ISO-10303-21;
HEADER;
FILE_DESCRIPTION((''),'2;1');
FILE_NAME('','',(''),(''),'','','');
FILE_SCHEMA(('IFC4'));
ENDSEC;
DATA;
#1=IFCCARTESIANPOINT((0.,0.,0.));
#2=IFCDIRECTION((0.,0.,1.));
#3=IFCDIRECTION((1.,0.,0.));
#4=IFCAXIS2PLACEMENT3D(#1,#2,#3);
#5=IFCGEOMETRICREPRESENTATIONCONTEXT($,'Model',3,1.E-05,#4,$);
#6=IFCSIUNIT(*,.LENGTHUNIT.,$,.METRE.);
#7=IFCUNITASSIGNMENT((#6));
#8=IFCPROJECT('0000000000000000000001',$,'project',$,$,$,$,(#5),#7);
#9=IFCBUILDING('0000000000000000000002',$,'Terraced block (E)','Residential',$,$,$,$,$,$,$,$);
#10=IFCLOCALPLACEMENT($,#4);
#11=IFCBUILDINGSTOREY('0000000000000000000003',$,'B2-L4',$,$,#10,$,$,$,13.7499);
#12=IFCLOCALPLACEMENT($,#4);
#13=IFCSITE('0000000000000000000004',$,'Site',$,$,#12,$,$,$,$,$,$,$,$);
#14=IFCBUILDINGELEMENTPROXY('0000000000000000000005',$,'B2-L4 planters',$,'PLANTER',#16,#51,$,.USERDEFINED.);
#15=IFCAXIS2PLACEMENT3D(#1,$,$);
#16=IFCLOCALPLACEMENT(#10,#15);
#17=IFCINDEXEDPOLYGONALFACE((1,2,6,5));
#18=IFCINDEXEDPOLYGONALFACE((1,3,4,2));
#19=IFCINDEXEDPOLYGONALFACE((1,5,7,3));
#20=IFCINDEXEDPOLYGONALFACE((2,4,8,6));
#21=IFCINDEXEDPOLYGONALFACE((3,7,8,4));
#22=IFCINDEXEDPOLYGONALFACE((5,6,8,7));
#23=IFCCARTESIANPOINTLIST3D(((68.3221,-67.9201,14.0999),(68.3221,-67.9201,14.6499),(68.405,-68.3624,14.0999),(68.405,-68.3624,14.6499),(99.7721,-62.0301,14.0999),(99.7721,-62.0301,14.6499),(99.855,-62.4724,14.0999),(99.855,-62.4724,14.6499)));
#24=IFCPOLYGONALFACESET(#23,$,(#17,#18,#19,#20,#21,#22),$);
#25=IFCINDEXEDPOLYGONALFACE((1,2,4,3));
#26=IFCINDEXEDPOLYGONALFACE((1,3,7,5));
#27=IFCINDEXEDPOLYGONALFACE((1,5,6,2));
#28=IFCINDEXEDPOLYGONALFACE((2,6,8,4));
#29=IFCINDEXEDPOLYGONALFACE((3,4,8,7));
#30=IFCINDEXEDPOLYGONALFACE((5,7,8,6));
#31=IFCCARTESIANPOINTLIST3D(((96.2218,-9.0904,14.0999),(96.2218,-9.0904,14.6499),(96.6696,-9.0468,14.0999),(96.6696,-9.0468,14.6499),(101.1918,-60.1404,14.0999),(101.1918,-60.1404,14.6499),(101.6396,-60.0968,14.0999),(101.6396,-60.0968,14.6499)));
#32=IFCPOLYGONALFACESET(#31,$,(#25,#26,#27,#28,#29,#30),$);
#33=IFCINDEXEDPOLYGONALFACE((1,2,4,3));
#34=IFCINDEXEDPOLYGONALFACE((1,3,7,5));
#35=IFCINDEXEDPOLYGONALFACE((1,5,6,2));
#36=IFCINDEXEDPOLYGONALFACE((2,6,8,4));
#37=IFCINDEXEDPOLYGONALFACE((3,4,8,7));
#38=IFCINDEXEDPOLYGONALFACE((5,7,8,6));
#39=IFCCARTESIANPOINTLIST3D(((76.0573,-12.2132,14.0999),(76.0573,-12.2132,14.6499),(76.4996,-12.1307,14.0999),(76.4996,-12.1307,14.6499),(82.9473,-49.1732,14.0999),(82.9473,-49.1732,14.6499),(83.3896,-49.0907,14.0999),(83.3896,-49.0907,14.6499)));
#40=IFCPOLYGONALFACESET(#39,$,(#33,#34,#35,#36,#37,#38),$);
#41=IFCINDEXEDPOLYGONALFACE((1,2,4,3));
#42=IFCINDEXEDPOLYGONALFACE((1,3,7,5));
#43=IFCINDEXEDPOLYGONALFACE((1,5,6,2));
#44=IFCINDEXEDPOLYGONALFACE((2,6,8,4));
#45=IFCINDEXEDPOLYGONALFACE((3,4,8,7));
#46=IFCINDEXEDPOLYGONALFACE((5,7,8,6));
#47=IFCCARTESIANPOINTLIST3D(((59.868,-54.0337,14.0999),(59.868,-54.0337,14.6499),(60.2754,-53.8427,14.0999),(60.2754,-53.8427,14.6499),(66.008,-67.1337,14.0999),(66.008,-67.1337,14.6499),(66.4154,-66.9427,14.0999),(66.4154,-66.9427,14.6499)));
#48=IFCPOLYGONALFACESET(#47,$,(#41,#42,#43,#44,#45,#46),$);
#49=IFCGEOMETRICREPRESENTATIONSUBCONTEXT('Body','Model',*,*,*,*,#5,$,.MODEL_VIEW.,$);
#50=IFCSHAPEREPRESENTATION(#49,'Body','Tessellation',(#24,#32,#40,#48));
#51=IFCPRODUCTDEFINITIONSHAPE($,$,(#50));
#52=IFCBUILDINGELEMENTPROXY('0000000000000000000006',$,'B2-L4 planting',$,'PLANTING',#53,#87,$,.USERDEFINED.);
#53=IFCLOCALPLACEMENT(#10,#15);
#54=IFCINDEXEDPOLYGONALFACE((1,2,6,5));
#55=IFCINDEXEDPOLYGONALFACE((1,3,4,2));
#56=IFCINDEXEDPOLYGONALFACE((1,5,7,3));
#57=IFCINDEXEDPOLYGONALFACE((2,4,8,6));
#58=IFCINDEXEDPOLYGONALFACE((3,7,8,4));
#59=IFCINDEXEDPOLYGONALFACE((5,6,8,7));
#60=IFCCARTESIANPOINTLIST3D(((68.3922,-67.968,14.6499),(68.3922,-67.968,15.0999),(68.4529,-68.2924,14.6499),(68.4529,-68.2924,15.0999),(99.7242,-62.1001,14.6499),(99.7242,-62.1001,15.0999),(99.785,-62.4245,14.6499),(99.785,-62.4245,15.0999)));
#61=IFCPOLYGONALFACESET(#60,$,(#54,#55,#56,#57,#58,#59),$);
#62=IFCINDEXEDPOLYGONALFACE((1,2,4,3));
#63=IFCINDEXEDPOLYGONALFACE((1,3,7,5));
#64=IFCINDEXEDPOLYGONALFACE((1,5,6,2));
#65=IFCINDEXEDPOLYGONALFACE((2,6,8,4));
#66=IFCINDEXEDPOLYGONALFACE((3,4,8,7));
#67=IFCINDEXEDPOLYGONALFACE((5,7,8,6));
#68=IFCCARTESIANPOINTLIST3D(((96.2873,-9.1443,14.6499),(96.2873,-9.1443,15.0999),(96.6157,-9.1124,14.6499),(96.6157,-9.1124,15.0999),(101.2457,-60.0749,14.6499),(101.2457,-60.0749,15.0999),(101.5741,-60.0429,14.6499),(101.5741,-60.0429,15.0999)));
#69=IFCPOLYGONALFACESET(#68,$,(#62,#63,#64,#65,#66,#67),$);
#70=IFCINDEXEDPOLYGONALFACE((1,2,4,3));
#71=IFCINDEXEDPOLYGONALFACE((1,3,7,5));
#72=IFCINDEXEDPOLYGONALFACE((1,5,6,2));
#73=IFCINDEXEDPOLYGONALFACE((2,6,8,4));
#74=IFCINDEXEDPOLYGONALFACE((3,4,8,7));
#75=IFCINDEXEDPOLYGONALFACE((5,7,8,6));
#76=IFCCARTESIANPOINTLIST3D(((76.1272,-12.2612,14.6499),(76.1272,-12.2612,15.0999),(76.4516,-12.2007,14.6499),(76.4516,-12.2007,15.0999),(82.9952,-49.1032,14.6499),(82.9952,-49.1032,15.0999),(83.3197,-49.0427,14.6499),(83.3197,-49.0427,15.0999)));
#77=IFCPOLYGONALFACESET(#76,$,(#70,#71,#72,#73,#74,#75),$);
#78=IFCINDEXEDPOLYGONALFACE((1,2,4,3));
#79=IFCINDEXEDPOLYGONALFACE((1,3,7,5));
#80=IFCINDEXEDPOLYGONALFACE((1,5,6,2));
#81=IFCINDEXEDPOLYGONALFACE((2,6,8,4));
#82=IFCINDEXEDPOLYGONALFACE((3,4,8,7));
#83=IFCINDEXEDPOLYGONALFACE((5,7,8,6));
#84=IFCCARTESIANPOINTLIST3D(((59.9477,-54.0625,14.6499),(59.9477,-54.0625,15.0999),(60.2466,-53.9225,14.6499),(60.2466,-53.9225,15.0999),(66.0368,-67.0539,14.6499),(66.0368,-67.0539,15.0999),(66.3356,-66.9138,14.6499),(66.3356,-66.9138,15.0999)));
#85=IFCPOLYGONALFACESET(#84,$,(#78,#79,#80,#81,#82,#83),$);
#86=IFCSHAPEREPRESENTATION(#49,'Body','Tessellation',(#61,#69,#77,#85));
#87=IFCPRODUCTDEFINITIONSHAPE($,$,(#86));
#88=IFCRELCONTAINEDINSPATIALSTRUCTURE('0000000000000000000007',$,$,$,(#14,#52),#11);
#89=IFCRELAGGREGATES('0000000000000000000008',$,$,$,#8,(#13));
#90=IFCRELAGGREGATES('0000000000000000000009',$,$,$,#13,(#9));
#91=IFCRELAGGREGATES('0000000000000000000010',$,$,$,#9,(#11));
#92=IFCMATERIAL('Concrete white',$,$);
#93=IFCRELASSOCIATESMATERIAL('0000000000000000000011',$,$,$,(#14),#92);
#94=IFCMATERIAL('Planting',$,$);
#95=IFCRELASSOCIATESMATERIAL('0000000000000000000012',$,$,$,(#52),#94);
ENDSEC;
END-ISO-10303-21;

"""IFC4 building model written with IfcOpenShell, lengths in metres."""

from ifc_helpers import new_model, si_unit, frame, origin_with_axes, place, context, subcontext, project, spatial, polyline, outline, extrude, material, element, save


model = new_model("IFC4")

# Units and contexts
model_context = context("Model", 3, precision=1e-05, world=origin_with_axes())
body_context = subcontext(model_context, "Body", "Model", "MODEL_VIEW")
ifc_project = project(units=[si_unit("LENGTHUNIT", "METRE")], contexts=[model_context])

# Site, building, storey
site_placement = place(None, origin_with_axes())
site = spatial("IfcSite", under=ifc_project, at=site_placement, Name="Site")
building = spatial("IfcBuilding", under=site, Name="Terraced block (E)", Description="Residential")
storey_placement = place(None, origin_with_axes())
storey = spatial("IfcBuildingStorey", under=building, at=storey_placement, Name="B2-L4", Elevation=13.7499)

# Shared definitions
ifc_material_1 = material(Name="Concrete white")

# Building element proxies
proxy_1_placement = place(storey_placement, origin_with_axes())
element("IfcBuildingElementProxy", 1, at=proxy_1_placement, inside=storey, material=ifc_material_1, Name="B2-L4 planters", ObjectType="PLANTER", PredefinedType="USERDEFINED", context=body_context, shape_type="SweptSolid", body=[
    extrude(outline(polyline([(68.405, -68.3624), (99.855, -62.4724), (99.7721, -62.0301), (68.3221, -67.9201), (68.405, -68.3624)])), frame((0.0, 0.0, 14.0999), z_axis=(0.0, 0.0, 1.0), x_axis=(1.0, 0.0, 0.0)), (0.0, 0.0, 1.0), 0.55),
    extrude(outline(polyline([(101.6396, -60.0968), (96.6696, -9.0468), (96.2218, -9.0904), (101.1918, -60.1404), (101.6396, -60.0968)])), frame((0.0, 0.0, 14.0999), z_axis=(0.0, 0.0, 1.0), x_axis=(1.0, 0.0, 0.0)), (0.0, 0.0, 1.0), 0.55),
    extrude(outline(polyline([(76.0573, -12.2132), (82.9473, -49.1732), (83.3896, -49.0907), (76.4996, -12.1307), (76.0573, -12.2132)])), frame((0.0, 0.0, 14.0999), z_axis=(0.0, 0.0, 1.0), x_axis=(1.0, 0.0, 0.0)), (0.0, 0.0, 1.0), 0.55),
    extrude(outline(polyline([(59.868, -54.0337), (66.008, -67.1337), (66.4154, -66.9427), (60.2754, -53.8427), (59.868, -54.0337)])), frame((0.0, 0.0, 14.0999), z_axis=(0.0, 0.0, 1.0), x_axis=(1.0, 0.0, 0.0)), (0.0, 0.0, 1.0), 0.55),
])
ifc_material_2 = material(Name="Planting")
proxy_2_placement = place(storey_placement, origin_with_axes())
element("IfcBuildingElementProxy", 2, at=proxy_2_placement, inside=storey, material=ifc_material_2, Name="B2-L4 planting", ObjectType="PLANTING", PredefinedType="USERDEFINED", context=body_context, shape_type="SweptSolid", body=[
    extrude(outline(polyline([(68.4529, -68.2924), (99.785, -62.4245), (99.7242, -62.1001), (68.3922, -67.968), (68.4529, -68.2924)])), frame((0.0, 0.0, 14.6499), z_axis=(0.0, 0.0, 1.0), x_axis=(1.0, 0.0, 0.0)), (0.0, 0.0, 1.0), 0.45),
    extrude(outline(polyline([(101.5741, -60.0429), (96.6157, -9.1124), (96.2873, -9.1443), (101.2457, -60.0749), (101.5741, -60.0429)])), frame((0.0, 0.0, 14.6499), z_axis=(0.0, 0.0, 1.0), x_axis=(1.0, 0.0, 0.0)), (0.0, 0.0, 1.0), 0.45),
    extrude(outline(polyline([(76.1272, -12.2612), (82.9952, -49.1032), (83.3197, -49.0427), (76.4516, -12.2007), (76.1272, -12.2612)])), frame((0.0, 0.0, 14.6499), z_axis=(0.0, 0.0, 1.0), x_axis=(1.0, 0.0, 0.0)), (0.0, 0.0, 1.0), 0.45),
    extrude(outline(polyline([(59.9477, -54.0625), (66.0368, -67.0539), (66.3356, -66.9138), (60.2466, -53.9225), (59.9477, -54.0625)])), frame((0.0, 0.0, 14.6499), z_axis=(0.0, 0.0, 1.0), x_axis=(1.0, 0.0, 0.0)), (0.0, 0.0, 1.0), 0.45),
])

save(model, "model.ifc")
